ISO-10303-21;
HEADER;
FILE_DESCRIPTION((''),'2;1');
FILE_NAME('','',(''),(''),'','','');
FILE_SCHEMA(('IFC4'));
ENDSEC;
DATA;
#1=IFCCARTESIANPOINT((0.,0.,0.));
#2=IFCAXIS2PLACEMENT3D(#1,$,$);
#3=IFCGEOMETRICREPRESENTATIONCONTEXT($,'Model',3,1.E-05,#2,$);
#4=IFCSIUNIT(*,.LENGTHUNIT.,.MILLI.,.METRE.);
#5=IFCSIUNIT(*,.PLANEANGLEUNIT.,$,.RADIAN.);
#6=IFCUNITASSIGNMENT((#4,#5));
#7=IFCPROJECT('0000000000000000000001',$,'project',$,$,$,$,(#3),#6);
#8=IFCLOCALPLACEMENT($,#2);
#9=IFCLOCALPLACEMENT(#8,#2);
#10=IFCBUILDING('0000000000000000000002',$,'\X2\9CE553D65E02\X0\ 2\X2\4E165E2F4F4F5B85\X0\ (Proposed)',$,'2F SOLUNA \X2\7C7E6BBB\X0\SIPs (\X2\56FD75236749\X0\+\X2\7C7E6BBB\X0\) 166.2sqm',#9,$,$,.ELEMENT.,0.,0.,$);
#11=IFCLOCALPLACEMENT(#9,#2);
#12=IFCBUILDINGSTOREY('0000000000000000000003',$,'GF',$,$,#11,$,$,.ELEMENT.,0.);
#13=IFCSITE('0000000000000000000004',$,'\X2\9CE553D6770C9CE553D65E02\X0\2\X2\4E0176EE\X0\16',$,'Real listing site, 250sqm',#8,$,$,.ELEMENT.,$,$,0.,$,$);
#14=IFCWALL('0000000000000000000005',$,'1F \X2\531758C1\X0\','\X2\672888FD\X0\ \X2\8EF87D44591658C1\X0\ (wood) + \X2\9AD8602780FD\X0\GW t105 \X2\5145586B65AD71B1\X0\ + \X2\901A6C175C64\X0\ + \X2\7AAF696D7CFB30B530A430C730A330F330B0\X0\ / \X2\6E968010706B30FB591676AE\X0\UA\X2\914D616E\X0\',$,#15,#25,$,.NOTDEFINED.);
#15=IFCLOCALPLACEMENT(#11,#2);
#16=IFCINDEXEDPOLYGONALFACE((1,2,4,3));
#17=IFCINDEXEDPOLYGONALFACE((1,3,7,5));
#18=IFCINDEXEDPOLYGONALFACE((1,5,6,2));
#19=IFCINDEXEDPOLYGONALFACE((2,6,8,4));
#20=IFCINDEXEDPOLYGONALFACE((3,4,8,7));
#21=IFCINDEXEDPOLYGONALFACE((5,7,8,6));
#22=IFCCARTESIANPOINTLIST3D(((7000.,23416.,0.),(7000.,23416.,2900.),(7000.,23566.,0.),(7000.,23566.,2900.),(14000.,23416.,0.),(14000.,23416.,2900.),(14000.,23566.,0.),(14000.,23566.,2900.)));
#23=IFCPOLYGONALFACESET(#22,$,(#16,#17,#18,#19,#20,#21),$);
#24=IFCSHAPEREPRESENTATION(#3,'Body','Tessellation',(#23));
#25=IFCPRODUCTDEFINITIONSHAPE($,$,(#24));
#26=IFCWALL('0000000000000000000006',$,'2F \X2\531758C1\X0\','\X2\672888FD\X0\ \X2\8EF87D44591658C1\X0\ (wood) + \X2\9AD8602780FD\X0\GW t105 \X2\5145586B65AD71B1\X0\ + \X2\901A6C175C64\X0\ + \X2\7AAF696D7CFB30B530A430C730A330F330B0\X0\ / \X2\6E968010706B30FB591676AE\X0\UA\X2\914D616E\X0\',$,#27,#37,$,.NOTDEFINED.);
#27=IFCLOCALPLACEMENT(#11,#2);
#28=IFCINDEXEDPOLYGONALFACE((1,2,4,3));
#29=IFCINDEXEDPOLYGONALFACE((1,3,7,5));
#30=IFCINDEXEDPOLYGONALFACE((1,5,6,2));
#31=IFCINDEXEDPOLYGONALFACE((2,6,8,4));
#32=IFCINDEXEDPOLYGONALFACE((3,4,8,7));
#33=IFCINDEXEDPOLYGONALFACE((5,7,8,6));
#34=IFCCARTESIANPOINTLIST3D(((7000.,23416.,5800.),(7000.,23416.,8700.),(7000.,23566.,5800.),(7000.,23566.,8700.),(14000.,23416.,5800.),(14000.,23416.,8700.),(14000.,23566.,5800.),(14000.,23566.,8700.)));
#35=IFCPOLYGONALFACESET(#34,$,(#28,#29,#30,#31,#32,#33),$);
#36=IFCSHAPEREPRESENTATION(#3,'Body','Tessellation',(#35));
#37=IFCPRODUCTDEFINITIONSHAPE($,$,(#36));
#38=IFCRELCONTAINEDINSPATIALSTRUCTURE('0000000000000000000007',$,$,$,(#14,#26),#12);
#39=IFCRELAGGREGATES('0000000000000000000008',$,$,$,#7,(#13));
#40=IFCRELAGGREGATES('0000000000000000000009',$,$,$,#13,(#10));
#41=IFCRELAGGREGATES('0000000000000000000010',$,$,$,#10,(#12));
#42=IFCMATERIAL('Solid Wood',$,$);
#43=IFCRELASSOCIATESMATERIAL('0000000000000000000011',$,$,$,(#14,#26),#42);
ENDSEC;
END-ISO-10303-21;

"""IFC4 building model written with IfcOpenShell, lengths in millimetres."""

from ifc_helpers import new_model, si_unit, frame, frame_2d, origin, place, context, project, spatial, rectangle, extrude, material, element, save


model = new_model("IFC4")

# Units and contexts
model_context = context("Model", 3, precision=1e-05, world=origin())
ifc_project = project(units=[si_unit("LENGTHUNIT", "METRE", prefix="MILLI"), si_unit("PLANEANGLEUNIT", "RADIAN")], contexts=[model_context])

# Site, building, storey
site_placement = place(None, origin())
site = spatial("IfcSite", under=ifc_project, at=site_placement, Name="鳥取県鳥取市2丁目16", ObjectType="Real listing site, 250sqm", CompositionType="ELEMENT", RefElevation=0.0)
building_placement = place(site_placement, origin())
building = spatial("IfcBuilding", under=site, at=building_placement, Name="鳥取市 2世帯住宅 (Proposed)", ObjectType="2F SOLUNA 籾殻SIPs (国産杉+籾殻) 166.2sqm", CompositionType="ELEMENT", ElevationOfRefHeight=0.0, ElevationOfTerrain=0.0)
storey_placement = place(building_placement, origin())
storey = spatial("IfcBuildingStorey", under=building, at=storey_placement, Name="GF", CompositionType="ELEMENT", Elevation=0.0)

# Shared definitions
ifc_material_1 = material(Name="Solid Wood")

# Wall
wall_1_placement = place(storey_placement, frame((3500.0, 11708.0, 0.0)))
element("IfcWall", 1, at=wall_1_placement, inside=storey, material=ifc_material_1, Name="1F 北壁", Description="木製 軸組外壁 (wood) + 高性能GW t105 充填断熱 + 通気層 + 窯業系サイディング / 準耐火・外皮UA配慮", PredefinedType="NOTDEFINED", context=model_context, shape_type="SweptSolid", body=[
    extrude(rectangle(XDim=7000.0, YDim=150.0, at=frame_2d((3500.0, 75.0))), frame((3500.0, 11708.0, 0.0)), (0.0, 0.0, 1.0), 2900.0),
])

# Wall
wall_2_placement = place(storey_placement, frame((3500.0, 11708.0, 2900.0)))
element("IfcWall", 2, at=wall_2_placement, inside=storey, material=ifc_material_1, Name="2F 北壁", Description="木製 軸組外壁 (wood) + 高性能GW t105 充填断熱 + 通気層 + 窯業系サイディング / 準耐火・外皮UA配慮", PredefinedType="NOTDEFINED", context=model_context, shape_type="SweptSolid", body=[
    extrude(rectangle(XDim=7000.0, YDim=150.0, at=frame_2d((3500.0, 75.0))), frame((3500.0, 11708.0, 2900.0)), (0.0, 0.0, 1.0), 2900.0),
])

save(model, "model.ifc")
